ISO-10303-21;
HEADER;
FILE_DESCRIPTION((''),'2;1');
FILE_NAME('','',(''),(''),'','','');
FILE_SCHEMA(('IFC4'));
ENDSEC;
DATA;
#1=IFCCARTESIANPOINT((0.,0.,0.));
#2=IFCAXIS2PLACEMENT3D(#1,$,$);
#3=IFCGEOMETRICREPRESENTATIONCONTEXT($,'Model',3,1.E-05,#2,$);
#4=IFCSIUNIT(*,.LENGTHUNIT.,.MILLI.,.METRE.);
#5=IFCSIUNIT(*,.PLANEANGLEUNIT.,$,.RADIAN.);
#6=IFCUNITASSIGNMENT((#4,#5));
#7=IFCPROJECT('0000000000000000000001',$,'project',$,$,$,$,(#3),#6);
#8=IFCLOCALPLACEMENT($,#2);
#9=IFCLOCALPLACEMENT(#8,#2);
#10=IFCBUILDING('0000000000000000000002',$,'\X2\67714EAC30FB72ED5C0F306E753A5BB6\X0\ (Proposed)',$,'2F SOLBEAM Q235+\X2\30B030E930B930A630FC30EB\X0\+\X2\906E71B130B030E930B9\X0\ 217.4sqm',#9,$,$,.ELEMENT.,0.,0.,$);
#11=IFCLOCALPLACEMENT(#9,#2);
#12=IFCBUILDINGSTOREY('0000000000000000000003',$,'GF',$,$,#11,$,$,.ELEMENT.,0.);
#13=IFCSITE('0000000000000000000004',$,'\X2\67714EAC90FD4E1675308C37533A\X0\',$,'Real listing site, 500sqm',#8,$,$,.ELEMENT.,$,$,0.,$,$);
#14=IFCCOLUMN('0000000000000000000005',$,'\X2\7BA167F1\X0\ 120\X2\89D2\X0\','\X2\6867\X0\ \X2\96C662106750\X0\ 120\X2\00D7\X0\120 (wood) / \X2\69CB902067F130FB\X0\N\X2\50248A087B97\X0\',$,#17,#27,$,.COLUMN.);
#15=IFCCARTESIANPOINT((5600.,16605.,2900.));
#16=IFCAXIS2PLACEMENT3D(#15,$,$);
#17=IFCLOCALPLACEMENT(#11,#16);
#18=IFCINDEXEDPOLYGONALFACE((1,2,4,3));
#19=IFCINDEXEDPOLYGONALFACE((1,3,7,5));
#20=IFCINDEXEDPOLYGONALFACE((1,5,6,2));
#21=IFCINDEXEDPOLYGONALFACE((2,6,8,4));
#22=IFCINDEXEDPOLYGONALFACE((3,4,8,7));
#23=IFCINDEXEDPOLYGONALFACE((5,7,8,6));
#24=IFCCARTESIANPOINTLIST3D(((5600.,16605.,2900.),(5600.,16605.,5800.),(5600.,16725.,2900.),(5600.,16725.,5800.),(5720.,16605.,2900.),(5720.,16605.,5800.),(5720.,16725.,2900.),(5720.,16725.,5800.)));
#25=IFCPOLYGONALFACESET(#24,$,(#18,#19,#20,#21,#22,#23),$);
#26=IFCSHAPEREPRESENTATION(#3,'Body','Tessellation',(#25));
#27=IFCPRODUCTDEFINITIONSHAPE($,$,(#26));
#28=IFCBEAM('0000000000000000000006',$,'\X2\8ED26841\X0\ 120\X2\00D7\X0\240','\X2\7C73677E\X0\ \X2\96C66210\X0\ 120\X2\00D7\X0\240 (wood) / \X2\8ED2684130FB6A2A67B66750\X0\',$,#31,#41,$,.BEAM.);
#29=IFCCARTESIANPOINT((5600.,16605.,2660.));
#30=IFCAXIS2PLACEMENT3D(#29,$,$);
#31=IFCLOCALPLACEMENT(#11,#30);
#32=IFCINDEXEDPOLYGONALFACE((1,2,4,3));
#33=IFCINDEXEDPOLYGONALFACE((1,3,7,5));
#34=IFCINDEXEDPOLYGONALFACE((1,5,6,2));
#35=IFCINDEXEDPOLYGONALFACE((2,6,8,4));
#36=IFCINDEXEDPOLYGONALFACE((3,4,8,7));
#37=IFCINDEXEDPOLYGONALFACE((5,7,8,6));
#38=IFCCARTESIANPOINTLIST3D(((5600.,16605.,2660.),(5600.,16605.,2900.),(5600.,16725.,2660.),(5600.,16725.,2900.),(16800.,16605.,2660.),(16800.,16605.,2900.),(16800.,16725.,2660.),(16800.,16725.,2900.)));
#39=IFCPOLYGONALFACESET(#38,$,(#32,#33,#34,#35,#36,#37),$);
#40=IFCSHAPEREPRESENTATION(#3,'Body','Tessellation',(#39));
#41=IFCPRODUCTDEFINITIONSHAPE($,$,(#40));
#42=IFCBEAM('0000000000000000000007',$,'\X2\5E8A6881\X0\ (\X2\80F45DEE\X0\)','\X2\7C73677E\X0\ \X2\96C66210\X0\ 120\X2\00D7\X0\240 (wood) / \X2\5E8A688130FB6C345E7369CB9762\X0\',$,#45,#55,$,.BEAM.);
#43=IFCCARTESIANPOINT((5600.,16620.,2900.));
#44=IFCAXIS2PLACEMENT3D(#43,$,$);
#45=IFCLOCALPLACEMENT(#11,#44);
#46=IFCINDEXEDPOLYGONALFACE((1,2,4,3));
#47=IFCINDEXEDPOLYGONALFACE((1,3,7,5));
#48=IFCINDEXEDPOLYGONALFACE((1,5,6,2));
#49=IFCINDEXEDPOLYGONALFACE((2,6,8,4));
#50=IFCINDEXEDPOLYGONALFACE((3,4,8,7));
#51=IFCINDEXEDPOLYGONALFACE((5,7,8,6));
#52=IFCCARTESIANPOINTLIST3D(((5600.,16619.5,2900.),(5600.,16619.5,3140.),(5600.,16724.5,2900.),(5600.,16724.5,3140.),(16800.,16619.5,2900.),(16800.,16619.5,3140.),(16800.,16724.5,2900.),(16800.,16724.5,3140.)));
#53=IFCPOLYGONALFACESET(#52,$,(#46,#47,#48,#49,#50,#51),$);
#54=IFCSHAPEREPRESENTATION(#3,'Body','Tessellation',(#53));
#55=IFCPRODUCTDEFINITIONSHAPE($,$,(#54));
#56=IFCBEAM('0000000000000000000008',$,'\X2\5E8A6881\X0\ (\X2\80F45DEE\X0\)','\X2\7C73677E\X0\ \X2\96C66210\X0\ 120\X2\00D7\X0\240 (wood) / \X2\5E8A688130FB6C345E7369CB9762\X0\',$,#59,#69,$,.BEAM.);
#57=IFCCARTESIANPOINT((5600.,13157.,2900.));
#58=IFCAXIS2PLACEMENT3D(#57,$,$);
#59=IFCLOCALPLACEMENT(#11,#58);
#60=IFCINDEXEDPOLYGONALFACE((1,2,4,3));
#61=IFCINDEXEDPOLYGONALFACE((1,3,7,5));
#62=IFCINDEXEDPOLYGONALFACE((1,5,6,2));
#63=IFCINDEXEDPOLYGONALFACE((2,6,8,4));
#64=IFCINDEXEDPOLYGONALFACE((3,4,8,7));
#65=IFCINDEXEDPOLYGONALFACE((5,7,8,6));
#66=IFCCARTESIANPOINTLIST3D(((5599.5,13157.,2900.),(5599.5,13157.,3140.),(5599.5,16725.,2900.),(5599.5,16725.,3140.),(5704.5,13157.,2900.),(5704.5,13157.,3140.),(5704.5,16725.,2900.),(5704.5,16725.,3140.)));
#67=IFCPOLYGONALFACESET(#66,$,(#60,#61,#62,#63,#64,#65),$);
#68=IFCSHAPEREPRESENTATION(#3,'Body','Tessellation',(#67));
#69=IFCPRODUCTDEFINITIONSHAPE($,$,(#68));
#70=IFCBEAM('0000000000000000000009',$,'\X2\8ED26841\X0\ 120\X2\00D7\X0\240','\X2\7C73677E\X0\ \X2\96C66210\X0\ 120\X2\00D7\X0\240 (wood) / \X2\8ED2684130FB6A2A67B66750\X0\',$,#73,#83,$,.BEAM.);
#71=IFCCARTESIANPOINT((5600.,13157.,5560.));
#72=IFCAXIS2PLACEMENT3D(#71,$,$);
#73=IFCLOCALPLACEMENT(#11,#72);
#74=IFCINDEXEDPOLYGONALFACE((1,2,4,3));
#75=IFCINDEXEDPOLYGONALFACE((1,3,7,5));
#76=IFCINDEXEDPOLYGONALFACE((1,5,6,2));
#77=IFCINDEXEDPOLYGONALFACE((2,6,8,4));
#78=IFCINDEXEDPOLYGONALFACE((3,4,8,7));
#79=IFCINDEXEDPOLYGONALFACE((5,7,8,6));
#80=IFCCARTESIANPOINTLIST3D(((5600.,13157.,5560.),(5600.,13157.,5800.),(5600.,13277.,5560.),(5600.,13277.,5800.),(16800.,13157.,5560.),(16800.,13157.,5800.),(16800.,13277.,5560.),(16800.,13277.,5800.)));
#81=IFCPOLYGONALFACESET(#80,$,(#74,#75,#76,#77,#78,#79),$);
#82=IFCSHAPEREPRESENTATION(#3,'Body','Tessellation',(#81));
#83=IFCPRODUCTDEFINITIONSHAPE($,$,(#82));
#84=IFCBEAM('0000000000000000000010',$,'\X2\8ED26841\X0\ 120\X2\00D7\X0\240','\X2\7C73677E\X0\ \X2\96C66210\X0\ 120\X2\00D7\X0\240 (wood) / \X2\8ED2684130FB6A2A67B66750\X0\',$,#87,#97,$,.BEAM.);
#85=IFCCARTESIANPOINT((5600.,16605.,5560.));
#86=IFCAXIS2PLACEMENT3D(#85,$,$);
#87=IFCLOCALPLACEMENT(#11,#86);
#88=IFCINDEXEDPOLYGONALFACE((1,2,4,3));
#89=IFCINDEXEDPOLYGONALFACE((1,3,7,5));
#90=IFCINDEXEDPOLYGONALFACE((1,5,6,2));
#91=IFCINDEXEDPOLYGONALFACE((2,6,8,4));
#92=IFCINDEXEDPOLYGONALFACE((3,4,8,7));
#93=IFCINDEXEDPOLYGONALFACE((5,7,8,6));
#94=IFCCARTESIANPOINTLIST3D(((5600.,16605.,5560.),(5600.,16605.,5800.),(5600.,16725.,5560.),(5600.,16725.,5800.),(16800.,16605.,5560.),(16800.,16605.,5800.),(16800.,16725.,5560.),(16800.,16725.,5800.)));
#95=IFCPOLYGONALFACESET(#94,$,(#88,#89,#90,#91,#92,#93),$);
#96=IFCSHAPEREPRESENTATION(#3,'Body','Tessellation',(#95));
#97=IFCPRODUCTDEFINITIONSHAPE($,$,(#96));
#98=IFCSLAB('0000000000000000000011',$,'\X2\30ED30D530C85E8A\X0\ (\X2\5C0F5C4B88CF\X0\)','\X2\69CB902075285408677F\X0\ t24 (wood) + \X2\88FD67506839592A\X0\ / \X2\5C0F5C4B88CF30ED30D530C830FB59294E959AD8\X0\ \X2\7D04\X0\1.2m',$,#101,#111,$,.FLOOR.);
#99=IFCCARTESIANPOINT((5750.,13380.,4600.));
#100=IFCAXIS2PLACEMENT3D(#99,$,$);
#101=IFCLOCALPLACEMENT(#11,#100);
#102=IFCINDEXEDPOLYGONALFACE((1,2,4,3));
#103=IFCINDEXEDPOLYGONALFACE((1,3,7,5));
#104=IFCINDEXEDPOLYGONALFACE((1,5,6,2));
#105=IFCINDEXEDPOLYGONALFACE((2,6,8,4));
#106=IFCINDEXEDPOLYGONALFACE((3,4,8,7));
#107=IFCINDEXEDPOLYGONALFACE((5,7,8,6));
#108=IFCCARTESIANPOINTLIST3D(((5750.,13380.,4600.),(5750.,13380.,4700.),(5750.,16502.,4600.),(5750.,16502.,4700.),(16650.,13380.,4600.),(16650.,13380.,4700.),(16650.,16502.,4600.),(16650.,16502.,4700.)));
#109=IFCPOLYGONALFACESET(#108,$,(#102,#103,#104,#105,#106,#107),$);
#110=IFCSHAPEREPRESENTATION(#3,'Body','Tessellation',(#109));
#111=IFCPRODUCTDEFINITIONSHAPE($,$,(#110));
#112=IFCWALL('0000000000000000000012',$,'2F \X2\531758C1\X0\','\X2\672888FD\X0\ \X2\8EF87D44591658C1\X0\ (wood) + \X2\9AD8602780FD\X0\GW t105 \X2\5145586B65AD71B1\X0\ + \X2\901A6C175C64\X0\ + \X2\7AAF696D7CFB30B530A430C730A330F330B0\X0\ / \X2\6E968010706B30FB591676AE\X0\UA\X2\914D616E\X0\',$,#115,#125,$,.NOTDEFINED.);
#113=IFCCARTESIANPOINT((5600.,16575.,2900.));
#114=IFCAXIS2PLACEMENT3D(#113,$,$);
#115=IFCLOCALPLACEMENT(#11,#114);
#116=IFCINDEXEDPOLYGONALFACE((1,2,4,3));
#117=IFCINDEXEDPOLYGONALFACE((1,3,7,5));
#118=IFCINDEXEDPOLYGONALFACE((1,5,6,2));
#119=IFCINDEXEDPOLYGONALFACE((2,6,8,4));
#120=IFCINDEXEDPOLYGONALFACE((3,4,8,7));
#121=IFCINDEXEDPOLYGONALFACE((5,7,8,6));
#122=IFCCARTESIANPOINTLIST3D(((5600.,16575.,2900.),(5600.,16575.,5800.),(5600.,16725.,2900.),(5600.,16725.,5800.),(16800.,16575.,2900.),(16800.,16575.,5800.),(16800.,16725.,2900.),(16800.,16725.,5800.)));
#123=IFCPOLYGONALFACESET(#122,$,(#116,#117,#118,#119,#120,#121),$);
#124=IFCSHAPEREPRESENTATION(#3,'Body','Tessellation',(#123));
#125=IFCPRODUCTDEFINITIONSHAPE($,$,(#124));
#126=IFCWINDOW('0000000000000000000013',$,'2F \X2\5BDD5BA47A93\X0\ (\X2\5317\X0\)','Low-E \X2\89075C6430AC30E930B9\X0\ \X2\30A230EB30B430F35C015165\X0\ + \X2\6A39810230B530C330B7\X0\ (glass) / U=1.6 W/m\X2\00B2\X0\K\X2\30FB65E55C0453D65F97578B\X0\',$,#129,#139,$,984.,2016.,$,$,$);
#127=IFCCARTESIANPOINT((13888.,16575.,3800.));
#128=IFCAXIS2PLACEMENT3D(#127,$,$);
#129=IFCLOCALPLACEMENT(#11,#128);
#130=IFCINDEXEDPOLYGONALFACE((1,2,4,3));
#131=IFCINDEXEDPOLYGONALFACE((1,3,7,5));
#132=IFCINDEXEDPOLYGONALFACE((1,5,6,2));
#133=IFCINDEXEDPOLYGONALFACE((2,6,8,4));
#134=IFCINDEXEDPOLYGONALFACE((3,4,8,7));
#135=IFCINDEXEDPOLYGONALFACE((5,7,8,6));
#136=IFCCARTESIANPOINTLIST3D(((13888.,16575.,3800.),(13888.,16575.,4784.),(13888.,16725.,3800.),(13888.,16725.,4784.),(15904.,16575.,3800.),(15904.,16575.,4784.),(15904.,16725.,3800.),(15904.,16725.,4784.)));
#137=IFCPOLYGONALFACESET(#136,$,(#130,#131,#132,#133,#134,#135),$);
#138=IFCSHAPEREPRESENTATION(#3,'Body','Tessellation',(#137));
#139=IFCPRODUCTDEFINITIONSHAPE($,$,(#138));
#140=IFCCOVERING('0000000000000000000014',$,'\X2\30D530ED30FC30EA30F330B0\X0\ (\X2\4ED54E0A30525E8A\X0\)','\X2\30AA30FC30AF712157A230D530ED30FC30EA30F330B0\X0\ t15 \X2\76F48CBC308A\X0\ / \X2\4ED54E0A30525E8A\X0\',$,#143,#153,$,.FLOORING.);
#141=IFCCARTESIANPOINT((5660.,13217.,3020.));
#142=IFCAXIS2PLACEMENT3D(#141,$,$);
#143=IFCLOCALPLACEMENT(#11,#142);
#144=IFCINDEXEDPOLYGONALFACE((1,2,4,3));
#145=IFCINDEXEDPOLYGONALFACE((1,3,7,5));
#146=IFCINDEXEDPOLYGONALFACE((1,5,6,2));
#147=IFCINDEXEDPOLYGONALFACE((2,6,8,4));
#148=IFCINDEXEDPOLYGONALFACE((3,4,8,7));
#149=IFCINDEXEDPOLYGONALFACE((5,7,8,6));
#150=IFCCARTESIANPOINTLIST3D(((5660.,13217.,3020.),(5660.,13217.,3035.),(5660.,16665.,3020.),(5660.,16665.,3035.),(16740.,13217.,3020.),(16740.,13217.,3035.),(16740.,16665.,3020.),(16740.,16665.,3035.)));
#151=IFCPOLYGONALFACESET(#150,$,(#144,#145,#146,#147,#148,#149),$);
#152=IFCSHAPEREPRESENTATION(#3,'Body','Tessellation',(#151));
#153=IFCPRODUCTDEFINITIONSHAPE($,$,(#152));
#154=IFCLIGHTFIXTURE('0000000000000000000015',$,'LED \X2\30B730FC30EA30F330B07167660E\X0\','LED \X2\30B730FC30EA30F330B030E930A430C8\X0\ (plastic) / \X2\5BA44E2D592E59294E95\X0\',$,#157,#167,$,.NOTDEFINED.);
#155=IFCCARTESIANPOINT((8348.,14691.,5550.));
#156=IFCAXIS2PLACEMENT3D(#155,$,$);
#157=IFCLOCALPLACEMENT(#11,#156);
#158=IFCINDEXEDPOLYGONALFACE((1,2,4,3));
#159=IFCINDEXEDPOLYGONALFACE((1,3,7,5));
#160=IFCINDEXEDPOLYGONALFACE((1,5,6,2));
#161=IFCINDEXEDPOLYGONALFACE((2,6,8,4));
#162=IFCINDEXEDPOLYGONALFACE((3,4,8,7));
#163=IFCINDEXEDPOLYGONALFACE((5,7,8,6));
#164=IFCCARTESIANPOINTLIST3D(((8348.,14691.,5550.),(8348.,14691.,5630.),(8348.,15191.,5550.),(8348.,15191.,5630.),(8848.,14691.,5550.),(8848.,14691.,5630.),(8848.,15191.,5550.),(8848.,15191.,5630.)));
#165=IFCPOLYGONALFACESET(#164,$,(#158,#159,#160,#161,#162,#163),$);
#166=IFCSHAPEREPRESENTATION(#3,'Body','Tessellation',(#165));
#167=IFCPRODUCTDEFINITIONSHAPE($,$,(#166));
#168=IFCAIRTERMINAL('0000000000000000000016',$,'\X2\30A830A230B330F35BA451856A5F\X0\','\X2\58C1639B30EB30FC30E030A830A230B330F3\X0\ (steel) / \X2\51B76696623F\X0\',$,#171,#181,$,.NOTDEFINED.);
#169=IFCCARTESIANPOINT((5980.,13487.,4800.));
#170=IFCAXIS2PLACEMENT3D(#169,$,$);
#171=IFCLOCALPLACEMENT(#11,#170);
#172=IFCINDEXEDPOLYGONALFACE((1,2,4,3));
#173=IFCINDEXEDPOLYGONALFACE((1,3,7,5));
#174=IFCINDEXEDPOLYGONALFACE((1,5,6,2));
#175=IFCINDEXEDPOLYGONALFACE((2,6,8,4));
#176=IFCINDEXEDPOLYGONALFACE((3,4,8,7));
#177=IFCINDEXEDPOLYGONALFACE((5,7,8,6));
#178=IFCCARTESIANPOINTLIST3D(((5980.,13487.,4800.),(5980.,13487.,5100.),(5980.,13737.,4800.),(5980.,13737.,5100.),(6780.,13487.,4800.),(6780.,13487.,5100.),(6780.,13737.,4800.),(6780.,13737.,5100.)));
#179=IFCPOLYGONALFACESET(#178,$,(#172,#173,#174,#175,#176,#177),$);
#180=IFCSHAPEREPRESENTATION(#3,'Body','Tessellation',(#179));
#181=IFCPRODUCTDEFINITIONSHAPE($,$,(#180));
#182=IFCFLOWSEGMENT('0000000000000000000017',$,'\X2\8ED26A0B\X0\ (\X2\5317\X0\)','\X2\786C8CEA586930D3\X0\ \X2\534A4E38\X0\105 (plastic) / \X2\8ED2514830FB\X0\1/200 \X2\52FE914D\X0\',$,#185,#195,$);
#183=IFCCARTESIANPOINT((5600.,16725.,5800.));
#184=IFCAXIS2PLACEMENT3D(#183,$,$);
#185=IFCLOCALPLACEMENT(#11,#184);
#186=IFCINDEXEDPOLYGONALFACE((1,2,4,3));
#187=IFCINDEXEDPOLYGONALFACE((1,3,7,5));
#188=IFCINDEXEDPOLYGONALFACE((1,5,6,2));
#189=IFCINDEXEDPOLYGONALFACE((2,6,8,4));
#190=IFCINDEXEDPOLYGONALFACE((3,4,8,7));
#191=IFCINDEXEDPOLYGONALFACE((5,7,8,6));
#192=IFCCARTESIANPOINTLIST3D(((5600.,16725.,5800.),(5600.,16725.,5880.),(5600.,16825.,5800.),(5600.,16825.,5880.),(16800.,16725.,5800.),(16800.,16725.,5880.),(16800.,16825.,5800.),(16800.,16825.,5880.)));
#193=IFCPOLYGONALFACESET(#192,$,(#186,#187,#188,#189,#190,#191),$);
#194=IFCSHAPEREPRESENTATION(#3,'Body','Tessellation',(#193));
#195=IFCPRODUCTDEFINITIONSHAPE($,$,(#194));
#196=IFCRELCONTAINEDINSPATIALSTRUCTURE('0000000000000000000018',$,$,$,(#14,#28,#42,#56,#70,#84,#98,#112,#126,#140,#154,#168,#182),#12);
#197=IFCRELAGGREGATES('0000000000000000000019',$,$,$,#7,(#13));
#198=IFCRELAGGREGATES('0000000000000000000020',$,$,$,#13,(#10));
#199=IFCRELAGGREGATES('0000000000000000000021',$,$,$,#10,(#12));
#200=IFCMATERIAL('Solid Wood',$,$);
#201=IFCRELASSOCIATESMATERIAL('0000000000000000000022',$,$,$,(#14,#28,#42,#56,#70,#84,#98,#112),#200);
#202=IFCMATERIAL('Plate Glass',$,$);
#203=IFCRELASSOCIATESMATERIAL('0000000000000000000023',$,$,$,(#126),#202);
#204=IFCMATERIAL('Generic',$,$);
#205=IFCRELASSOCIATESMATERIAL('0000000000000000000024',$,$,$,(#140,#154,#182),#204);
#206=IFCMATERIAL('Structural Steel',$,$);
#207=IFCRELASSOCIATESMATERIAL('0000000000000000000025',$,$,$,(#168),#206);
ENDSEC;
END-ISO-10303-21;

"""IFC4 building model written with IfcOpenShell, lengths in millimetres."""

from ifc_helpers import new_model, si_unit, frame, frame_2d, origin, place, context, project, spatial, rectangle, extrude, material, element, fill, save


model = new_model("IFC4")

# Units and contexts
model_context = context("Model", 3, precision=1e-05, world=origin())
ifc_project = project(units=[si_unit("LENGTHUNIT", "METRE", prefix="MILLI"), si_unit("PLANEANGLEUNIT", "RADIAN")], contexts=[model_context])

# Site, building, storey
site_placement = place(None, origin())
site = spatial("IfcSite", under=ifc_project, at=site_placement, Name="東京都世田谷区", ObjectType="Real listing site, 500sqm", CompositionType="ELEMENT", RefElevation=0.0)
building_placement = place(site_placement, origin())
building = spatial("IfcBuilding", under=site, at=building_placement, Name="東京・狭小の町家 (Proposed)", ObjectType="2F SOLBEAM Q235+グラスウール+遮熱グラス 217.4sqm", CompositionType="ELEMENT", ElevationOfRefHeight=0.0, ElevationOfTerrain=0.0)
storey_placement = place(building_placement, origin())
storey = spatial("IfcBuildingStorey", under=building, at=storey_placement, Name="GF", CompositionType="ELEMENT", Elevation=0.0)

# Column
ifc_material_1 = material(Name="Solid Wood")
column_1_placement = place(storey_placement, frame((5600.0, 16605.0, 2900.0)))
element("IfcColumn", 1, at=column_1_placement, inside=storey, material=ifc_material_1, Name="管柱 120角", Description="桧 集成材 120×120 (wood) / 構造柱・N値計算", PredefinedType="COLUMN", context=model_context, shape_type="SweptSolid", body=[
    extrude(rectangle(XDim=120.0, YDim=120.0, at=frame_2d((60.0, 60.0))), frame((5600.0, 16605.0, 2900.0)), (0.0, 0.0, 1.0), 2900.0),
])

# Beams
beam_1_placement = place(storey_placement, frame((5600.0, 16605.0, 2660.0)))
element("IfcBeam", 2, at=beam_1_placement, inside=storey, material=ifc_material_1, Name="軒桁 120×240", Description="米松 集成 120×240 (wood) / 軒桁・横架材", PredefinedType="BEAM", context=model_context, shape_type="SweptSolid", body=[
    extrude(rectangle(XDim=11200.0, YDim=120.0, at=frame_2d((5600.0, 60.0))), frame((5600.0, 16605.0, 2660.0)), (0.0, 0.0, 1.0), 240.0),
])
beam_2_placement = place(storey_placement, frame((5600.0, 16620.0, 2900.0)))
element("IfcBeam", 3, at=beam_2_placement, inside=storey, material=ifc_material_1, Name="床梁 (胴差)", Description="米松 集成 120×240 (wood) / 床梁・水平構面", PredefinedType="BEAM", context=model_context, shape_type="SweptSolid", body=[
    extrude(rectangle(XDim=11200.0, YDim=105.0, at=frame_2d((5600.0, 52.0))), frame((5600.0, 16620.0, 2900.0)), (0.0, 0.0, 1.0), 240.0),
])
beam_3_placement = place(storey_placement, frame((5600.0, 13157.0, 2900.0)))
element("IfcBeam", 4, at=beam_3_placement, inside=storey, material=ifc_material_1, Name="床梁 (胴差)", Description="米松 集成 120×240 (wood) / 床梁・水平構面", PredefinedType="BEAM", context=model_context, shape_type="SweptSolid", body=[
    extrude(rectangle(XDim=105.0, YDim=3568.0, at=frame_2d((52.0, 1784.0))), frame((5600.0, 13157.0, 2900.0)), (0.0, 0.0, 1.0), 240.0),
])
beam_4_placement = place(storey_placement, frame((5600.0, 13157.0, 5560.0)))
element("IfcBeam", 5, at=beam_4_placement, inside=storey, material=ifc_material_1, Name="軒桁 120×240", Description="米松 集成 120×240 (wood) / 軒桁・横架材", PredefinedType="BEAM", context=model_context, shape_type="SweptSolid", body=[
    extrude(rectangle(XDim=11200.0, YDim=120.0, at=frame_2d((5600.0, 60.0))), frame((5600.0, 13157.0, 5560.0)), (0.0, 0.0, 1.0), 240.0),
])
beam_5_placement = place(storey_placement, frame((5600.0, 16605.0, 5560.0)))
element("IfcBeam", 6, at=beam_5_placement, inside=storey, material=ifc_material_1, Name="軒桁 120×240", Description="米松 集成 120×240 (wood) / 軒桁・横架材", PredefinedType="BEAM", context=model_context, shape_type="SweptSolid", body=[
    extrude(rectangle(XDim=11200.0, YDim=120.0, at=frame_2d((5600.0, 60.0))), frame((5600.0, 16605.0, 5560.0)), (0.0, 0.0, 1.0), 240.0),
])

# Slab
slab_placement = place(storey_placement, frame((5750.0, 13380.0, 4600.0)))
element("IfcSlab", 7, at=slab_placement, inside=storey, material=ifc_material_1, Name="ロフト床 (小屋裏)", Description="構造用合板 t24 (wood) + 製材根太 / 小屋裏ロフト・天井高 約1.2m", PredefinedType="FLOOR", context=model_context, shape_type="SweptSolid", body=[
    extrude(rectangle(XDim=10900.0, YDim=3122.0, at=frame_2d((5450.0, 1561.0))), frame((5750.0, 13380.0, 4600.0)), (0.0, 0.0, 1.0), 100.0),
])

# Wall, opening, window
wall_placement = place(storey_placement, frame((5600.0, 16575.0, 2900.0)))
wall = element("IfcWall", 8, at=wall_placement, inside=storey, material=ifc_material_1, Name="2F 北壁", Description="木製 軸組外壁 (wood) + 高性能GW t105 充填断熱 + 通気層 + 窯業系サイディング / 準耐火・外皮UA配慮", PredefinedType="NOTDEFINED", context=model_context, shape_type="SweptSolid", body=[
    extrude(rectangle(XDim=11200.0, YDim=150.0, at=frame_2d((5600.0, 75.0))), frame((5600.0, 16575.0, 2900.0)), (0.0, 0.0, 1.0), 2900.0),
])
opening_placement = place(storey_placement, frame((13888.0, 16575.0, 3800.0)))
opening = element("IfcOpeningElement", 9, at=opening_placement, cuts=wall, PredefinedType="NOTDEFINED", context=model_context, shape_type="SweptSolid", body=[
    extrude(rectangle(XDim=2016.0, YDim=150.0, at=frame_2d((1008.0, 75.0))), frame((13888.0, 16575.0, 3800.0)), (0.0, 0.0, 1.0), 984.0),
])
ifc_material_2 = material(Name="Plate Glass")
window_placement = place(storey_placement, frame((13888.0, 16575.0, 3800.0)))
window = element("IfcWindow", 10, at=window_placement, inside=storey, material=ifc_material_2, Name="2F 寝室窓 (北)", Description="Low-E 複層ガラス アルゴン封入 + 樹脂サッシ (glass) / U=1.6 W/m²K・日射取得型", OverallHeight=984.0, OverallWidth=2016.0, context=model_context, shape_type="SweptSolid", body=[
    extrude(rectangle(XDim=2016.0, YDim=150.0, at=frame_2d((1008.0, 75.0))), frame((13888.0, 16575.0, 3800.0)), (0.0, 0.0, 1.0), 984.0),
])
fill(opening, window)

# Covering
ifc_material_3 = material(Name="Generic")
covering_placement = place(storey_placement, frame((5660.0, 13217.0, 3020.0)))
element("IfcCovering", 11, at=covering_placement, inside=storey, material=ifc_material_3, Name="フローリング (仕上げ床)", Description="オーク無垢フローリング t15 直貼り / 仕上げ床", PredefinedType="FLOORING", context=model_context, shape_type="SweptSolid", body=[
    extrude(rectangle(XDim=11080.0, YDim=3448.0, at=frame_2d((5540.0, 1724.0))), frame((5660.0, 13217.0, 3020.0)), (0.0, 0.0, 1.0), 15.0),
])

# Light fixture
light_fixture_placement = place(storey_placement, frame((8348.0, 14691.0, 5550.0)))
element("IfcLightFixture", 12, at=light_fixture_placement, inside=storey, material=ifc_material_3, Name="LED シーリング照明", Description="LED シーリングライト (plastic) / 室中央天井", PredefinedType="NOTDEFINED", context=model_context, shape_type="SweptSolid", body=[
    extrude(rectangle(XDim=500.0, YDim=500.0, at=frame_2d((250.0, 250.0))), frame((8348.0, 14691.0, 5550.0)), (0.0, 0.0, 1.0), 80.0),
])

# Air terminal
ifc_material_4 = material(Name="Structural Steel")
air_terminal_placement = place(storey_placement, frame((5980.0, 13487.0, 4800.0)))
element("IfcAirTerminal", 13, at=air_terminal_placement, inside=storey, material=ifc_material_4, Name="エアコン室内機", Description="壁掛ルームエアコン (steel) / 冷暖房", PredefinedType="NOTDEFINED", context=model_context, shape_type="SweptSolid", body=[
    extrude(rectangle(XDim=800.0, YDim=250.0, at=frame_2d((400.0, 125.0))), frame((5980.0, 13487.0, 4800.0)), (0.0, 0.0, 1.0), 300.0),
])

# Flow segment
flow_segment_placement = place(storey_placement, frame((5600.0, 16725.0, 5800.0)))
element("IfcFlowSegment", 14, at=flow_segment_placement, inside=storey, material=ifc_material_3, Name="軒樋 (北)", Description="硬質塩ビ 半丸105 (plastic) / 軒先・1/200 勾配", context=model_context, shape_type="SweptSolid", body=[
    extrude(rectangle(XDim=11200.0, YDim=100.0, at=frame_2d((5600.0, 50.0))), frame((5600.0, 16725.0, 5800.0)), (0.0, 0.0, 1.0), 80.0),
])

save(model, "model.ifc")
